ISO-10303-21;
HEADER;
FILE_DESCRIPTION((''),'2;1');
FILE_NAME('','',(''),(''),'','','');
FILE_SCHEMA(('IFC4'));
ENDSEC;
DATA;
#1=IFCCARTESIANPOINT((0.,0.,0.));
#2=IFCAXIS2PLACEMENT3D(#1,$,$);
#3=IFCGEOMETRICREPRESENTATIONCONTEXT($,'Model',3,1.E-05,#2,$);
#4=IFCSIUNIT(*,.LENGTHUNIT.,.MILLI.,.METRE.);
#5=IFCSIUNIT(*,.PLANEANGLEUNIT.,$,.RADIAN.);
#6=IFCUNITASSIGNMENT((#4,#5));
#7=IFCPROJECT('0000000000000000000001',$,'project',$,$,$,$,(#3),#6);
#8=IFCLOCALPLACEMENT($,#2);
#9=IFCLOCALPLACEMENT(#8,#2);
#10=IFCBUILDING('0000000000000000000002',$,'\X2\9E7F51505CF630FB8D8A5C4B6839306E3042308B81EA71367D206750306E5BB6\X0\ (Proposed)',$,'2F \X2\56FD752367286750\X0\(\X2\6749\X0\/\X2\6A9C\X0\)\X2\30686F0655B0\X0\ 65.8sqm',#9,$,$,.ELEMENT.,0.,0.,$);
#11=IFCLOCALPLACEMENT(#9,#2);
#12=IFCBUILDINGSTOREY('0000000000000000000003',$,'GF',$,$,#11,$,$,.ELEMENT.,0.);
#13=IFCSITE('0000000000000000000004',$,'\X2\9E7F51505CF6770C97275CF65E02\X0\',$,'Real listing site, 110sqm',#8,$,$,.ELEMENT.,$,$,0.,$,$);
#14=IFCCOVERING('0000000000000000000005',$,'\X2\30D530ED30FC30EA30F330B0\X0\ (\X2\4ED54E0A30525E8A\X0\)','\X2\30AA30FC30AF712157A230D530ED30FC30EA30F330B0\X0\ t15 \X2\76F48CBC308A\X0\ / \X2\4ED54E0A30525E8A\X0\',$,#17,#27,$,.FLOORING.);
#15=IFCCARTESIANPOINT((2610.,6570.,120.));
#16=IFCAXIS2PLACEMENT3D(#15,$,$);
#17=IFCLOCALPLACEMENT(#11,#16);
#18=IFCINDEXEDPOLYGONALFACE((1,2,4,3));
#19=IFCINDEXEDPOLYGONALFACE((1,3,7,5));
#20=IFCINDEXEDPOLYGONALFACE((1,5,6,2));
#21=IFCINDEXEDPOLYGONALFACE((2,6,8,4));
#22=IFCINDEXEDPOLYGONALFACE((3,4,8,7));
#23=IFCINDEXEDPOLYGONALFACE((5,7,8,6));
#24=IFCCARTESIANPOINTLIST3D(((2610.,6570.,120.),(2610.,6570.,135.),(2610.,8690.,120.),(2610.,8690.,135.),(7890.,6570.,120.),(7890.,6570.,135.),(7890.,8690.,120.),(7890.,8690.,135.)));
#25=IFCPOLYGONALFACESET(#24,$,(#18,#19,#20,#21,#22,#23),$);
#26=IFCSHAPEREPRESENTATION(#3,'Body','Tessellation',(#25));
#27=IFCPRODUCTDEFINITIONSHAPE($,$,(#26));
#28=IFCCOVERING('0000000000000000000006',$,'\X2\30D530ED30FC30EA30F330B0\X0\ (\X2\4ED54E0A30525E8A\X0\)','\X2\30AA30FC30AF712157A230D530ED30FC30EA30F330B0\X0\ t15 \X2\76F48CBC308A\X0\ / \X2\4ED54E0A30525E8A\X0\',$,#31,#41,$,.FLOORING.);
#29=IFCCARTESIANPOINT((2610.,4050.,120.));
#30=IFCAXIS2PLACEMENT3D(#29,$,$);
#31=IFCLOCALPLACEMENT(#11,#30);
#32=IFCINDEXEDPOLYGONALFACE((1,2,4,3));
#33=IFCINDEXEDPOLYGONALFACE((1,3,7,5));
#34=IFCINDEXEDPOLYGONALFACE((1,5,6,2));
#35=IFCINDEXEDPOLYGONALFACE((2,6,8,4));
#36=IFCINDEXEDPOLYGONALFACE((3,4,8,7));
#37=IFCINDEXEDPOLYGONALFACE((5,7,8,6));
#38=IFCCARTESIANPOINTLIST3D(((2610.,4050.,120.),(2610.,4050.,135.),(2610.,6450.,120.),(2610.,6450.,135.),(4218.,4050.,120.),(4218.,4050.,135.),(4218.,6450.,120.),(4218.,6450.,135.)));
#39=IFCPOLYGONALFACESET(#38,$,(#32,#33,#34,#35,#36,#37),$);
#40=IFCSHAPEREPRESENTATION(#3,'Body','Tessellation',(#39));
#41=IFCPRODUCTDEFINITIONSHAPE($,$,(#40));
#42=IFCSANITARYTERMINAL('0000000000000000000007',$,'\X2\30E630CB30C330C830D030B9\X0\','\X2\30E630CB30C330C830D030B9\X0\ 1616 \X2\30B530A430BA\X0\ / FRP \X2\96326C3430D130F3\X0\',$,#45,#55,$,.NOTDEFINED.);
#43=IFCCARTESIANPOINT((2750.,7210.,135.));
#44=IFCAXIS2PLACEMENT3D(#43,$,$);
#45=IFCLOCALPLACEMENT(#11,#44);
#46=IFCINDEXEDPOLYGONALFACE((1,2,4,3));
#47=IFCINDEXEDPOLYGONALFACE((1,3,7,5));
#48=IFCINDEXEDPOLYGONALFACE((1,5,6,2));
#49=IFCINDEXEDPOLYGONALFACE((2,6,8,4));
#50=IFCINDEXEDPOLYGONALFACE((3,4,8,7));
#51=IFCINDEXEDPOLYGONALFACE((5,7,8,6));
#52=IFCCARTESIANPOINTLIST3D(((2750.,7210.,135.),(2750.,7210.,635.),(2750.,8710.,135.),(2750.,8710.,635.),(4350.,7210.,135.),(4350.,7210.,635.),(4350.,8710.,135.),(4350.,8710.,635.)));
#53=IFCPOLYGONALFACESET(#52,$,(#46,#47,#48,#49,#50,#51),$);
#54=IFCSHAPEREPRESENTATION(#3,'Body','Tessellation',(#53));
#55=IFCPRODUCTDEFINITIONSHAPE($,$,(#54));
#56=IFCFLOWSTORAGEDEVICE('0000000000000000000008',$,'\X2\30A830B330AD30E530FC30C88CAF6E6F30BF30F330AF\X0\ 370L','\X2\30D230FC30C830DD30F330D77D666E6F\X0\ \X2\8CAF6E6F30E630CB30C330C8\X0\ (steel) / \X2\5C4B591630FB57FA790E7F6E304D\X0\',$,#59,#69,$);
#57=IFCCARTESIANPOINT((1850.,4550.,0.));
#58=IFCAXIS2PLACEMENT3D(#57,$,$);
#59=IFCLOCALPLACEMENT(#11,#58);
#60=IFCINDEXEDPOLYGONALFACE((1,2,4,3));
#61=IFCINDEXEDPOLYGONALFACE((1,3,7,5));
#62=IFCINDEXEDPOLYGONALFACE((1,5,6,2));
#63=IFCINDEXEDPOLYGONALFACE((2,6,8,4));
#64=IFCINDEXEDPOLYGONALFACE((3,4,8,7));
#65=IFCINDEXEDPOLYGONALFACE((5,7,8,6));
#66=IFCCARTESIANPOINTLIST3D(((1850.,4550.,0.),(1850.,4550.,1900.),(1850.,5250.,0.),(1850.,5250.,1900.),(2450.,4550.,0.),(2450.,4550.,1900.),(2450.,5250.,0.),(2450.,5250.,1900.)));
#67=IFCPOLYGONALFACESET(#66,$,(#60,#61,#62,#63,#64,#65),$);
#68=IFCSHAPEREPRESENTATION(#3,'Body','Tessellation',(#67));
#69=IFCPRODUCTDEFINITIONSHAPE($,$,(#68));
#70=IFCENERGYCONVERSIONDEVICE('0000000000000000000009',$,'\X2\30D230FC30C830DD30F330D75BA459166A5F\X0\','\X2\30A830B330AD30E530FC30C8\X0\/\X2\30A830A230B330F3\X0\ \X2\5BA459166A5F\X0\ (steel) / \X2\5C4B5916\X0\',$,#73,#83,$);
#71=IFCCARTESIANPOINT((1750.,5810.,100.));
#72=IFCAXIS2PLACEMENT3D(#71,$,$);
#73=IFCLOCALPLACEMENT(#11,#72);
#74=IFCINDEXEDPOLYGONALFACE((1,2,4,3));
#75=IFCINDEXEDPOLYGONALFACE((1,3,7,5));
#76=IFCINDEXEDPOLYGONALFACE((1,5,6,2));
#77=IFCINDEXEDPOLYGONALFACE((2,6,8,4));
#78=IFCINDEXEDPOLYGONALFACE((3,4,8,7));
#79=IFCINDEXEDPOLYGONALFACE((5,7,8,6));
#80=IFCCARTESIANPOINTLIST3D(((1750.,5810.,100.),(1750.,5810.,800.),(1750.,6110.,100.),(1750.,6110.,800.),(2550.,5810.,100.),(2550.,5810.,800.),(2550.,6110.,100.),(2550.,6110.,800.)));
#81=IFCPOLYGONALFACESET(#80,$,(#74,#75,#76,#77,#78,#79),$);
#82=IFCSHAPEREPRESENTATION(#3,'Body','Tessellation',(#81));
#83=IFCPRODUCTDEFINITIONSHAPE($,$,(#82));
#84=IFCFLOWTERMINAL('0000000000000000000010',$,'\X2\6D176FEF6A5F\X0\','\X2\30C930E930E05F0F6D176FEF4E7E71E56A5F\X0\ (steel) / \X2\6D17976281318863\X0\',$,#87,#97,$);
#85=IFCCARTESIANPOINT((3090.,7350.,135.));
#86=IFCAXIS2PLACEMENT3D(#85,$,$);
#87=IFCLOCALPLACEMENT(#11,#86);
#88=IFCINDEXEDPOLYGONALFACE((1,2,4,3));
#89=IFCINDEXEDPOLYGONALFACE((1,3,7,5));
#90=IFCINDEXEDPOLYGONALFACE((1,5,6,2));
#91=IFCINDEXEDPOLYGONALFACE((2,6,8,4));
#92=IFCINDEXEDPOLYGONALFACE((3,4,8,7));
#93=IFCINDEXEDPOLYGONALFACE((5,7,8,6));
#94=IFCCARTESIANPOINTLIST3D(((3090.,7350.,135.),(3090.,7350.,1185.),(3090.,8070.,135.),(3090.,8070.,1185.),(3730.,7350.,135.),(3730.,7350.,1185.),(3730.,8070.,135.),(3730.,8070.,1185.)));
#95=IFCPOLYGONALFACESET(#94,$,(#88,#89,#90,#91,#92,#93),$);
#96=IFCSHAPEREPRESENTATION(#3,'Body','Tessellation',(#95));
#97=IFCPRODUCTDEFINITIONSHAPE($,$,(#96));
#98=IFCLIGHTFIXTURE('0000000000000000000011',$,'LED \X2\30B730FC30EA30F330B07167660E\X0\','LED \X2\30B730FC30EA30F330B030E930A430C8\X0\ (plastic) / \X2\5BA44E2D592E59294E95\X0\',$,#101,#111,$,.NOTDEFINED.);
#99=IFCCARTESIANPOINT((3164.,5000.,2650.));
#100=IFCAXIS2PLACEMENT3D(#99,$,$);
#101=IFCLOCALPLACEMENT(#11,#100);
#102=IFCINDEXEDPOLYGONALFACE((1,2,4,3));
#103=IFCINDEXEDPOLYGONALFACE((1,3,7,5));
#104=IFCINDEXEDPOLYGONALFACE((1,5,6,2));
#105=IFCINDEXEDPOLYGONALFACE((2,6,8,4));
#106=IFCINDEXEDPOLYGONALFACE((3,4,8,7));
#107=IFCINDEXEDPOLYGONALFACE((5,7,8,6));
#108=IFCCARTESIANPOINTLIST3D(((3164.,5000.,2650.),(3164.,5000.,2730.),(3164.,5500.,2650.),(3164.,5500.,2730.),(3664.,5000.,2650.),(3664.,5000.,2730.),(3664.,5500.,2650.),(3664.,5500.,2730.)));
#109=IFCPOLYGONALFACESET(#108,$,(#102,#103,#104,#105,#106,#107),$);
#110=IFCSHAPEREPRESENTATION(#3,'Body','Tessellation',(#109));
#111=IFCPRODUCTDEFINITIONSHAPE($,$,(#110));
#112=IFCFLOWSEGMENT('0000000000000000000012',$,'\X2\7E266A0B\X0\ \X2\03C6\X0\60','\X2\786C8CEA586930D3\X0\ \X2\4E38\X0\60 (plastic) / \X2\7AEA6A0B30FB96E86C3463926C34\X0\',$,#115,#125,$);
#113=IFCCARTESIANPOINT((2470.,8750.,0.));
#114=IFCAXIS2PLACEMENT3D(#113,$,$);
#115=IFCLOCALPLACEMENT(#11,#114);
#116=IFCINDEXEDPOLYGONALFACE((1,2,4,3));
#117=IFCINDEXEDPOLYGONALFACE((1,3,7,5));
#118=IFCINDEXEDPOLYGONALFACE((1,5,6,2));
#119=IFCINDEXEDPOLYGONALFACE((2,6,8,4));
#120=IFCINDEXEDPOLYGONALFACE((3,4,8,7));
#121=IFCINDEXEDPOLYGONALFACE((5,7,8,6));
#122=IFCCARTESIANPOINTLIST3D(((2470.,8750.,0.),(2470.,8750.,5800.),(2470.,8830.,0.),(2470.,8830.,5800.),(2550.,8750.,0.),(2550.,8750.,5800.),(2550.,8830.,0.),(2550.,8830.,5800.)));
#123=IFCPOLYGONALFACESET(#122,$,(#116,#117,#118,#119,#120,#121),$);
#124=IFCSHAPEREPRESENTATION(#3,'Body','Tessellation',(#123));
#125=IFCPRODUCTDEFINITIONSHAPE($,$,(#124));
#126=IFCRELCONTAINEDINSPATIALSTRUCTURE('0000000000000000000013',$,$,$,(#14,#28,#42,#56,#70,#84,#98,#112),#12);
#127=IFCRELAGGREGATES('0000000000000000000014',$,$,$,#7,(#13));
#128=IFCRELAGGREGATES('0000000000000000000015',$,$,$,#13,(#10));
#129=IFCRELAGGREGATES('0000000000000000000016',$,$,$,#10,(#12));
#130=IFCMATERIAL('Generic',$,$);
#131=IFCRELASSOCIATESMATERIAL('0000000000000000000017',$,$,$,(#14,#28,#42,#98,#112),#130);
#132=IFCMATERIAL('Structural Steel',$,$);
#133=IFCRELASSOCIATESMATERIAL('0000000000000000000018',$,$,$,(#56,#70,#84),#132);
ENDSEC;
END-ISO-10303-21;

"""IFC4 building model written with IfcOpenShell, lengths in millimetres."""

from ifc_helpers import new_model, si_unit, frame, frame_2d, origin, place, context, project, spatial, rectangle, extrude, material, element, save


model = new_model("IFC4")

# Units and contexts
model_context = context("Model", 3, precision=1e-05, world=origin())
ifc_project = project(units=[si_unit("LENGTHUNIT", "METRE", prefix="MILLI"), si_unit("PLANEANGLEUNIT", "RADIAN")], contexts=[model_context])

# Site, building, storey
site_placement = place(None, origin())
site = spatial("IfcSite", under=ifc_project, at=site_placement, Name="鹿児島県霧島市", ObjectType="Real listing site, 110sqm", CompositionType="ELEMENT", RefElevation=0.0)
building_placement = place(site_placement, origin())
building = spatial("IfcBuilding", under=site, at=building_placement, Name="鹿児島・越屋根のある自然素材の家 (Proposed)", ObjectType="2F 国産木材(杉/檜)と漆喰 65.8sqm", CompositionType="ELEMENT", ElevationOfRefHeight=0.0, ElevationOfTerrain=0.0)
storey_placement = place(building_placement, origin())
storey = spatial("IfcBuildingStorey", under=building, at=storey_placement, Name="GF", CompositionType="ELEMENT", Elevation=0.0)

# Coverings
ifc_material_1 = material(Name="Generic")
covering_1_placement = place(storey_placement, frame((2610.0, 6570.0, 120.0)))
element("IfcCovering", 1, at=covering_1_placement, inside=storey, material=ifc_material_1, Name="フローリング (仕上げ床)", Description="オーク無垢フローリング t15 直貼り / 仕上げ床", PredefinedType="FLOORING", context=model_context, shape_type="SweptSolid", body=[
    extrude(rectangle(XDim=5280.0, YDim=2120.0, at=frame_2d((2640.0, 1060.0))), frame((2610.0, 6570.0, 120.0)), (0.0, 0.0, 1.0), 15.0),
])
covering_2_placement = place(storey_placement, frame((2610.0, 4050.0, 120.0)))
element("IfcCovering", 2, at=covering_2_placement, inside=storey, material=ifc_material_1, Name="フローリング (仕上げ床)", Description="オーク無垢フローリング t15 直貼り / 仕上げ床", PredefinedType="FLOORING", context=model_context, shape_type="SweptSolid", body=[
    extrude(rectangle(XDim=1608.0, YDim=2400.0, at=frame_2d((804.0, 1200.0))), frame((2610.0, 4050.0, 120.0)), (0.0, 0.0, 1.0), 15.0),
])

# Sanitary terminal
sanitary_terminal_placement = place(storey_placement, frame((2750.0, 7210.0, 135.0)))
element("IfcSanitaryTerminal", 3, at=sanitary_terminal_placement, inside=storey, material=ifc_material_1, Name="ユニットバス", Description="ユニットバス 1616 サイズ / FRP 防水パン", PredefinedType="NOTDEFINED", context=model_context, shape_type="SweptSolid", body=[
    extrude(rectangle(XDim=1600.0, YDim=1500.0, at=frame_2d((800.0, 750.0))), frame((2750.0, 7210.0, 135.0)), (0.0, 0.0, 1.0), 500.0),
])

# Flow storage device
ifc_material_2 = material(Name="Structural Steel")
flow_storage_device_placement = place(storey_placement, frame((1850.0, 4550.0, 0.0)))
element("IfcFlowStorageDevice", 4, at=flow_storage_device_placement, inside=storey, material=ifc_material_2, Name="エコキュート貯湯タンク 370L", Description="ヒートポンプ給湯 貯湯ユニット (steel) / 屋外・基礎置き", context=model_context, shape_type="SweptSolid", body=[
    extrude(rectangle(XDim=600.0, YDim=700.0, at=frame_2d((300.0, 350.0))), frame((1850.0, 4550.0, 0.0)), (0.0, 0.0, 1.0), 1900.0),
])

# Energy conversion device
energy_conversion_device_placement = place(storey_placement, frame((1750.0, 5810.0, 100.0)))
element("IfcEnergyConversionDevice", 5, at=energy_conversion_device_placement, inside=storey, material=ifc_material_2, Name="ヒートポンプ室外機", Description="エコキュート/エアコン 室外機 (steel) / 屋外", context=model_context, shape_type="SweptSolid", body=[
    extrude(rectangle(XDim=800.0, YDim=300.0, at=frame_2d((400.0, 150.0))), frame((1750.0, 5810.0, 100.0)), (0.0, 0.0, 1.0), 700.0),
])

# Flow terminal
flow_terminal_placement = place(storey_placement, frame((3090.0, 7350.0, 135.0)))
element("IfcFlowTerminal", 6, at=flow_terminal_placement, inside=storey, material=ifc_material_2, Name="洗濯機", Description="ドラム式洗濯乾燥機 (steel) / 洗面脱衣", context=model_context, shape_type="SweptSolid", body=[
    extrude(rectangle(XDim=640.0, YDim=720.0, at=frame_2d((320.0, 360.0))), frame((3090.0, 7350.0, 135.0)), (0.0, 0.0, 1.0), 1050.0),
])

# Light fixture
light_fixture_placement = place(storey_placement, frame((3164.0, 5000.0, 2650.0)))
element("IfcLightFixture", 7, at=light_fixture_placement, inside=storey, material=ifc_material_1, Name="LED シーリング照明", Description="LED シーリングライト (plastic) / 室中央天井", PredefinedType="NOTDEFINED", context=model_context, shape_type="SweptSolid", body=[
    extrude(rectangle(XDim=500.0, YDim=500.0, at=frame_2d((250.0, 250.0))), frame((3164.0, 5000.0, 2650.0)), (0.0, 0.0, 1.0), 80.0),
])

# Flow segment
flow_segment_placement = place(storey_placement, frame((2470.0, 8750.0, 0.0)))
element("IfcFlowSegment", 8, at=flow_segment_placement, inside=storey, material=ifc_material_1, Name="縦樋 φ60", Description="硬質塩ビ 丸60 (plastic) / 竪樋・雨水排水", context=model_context, shape_type="SweptSolid", body=[
    extrude(rectangle(XDim=80.0, YDim=80.0, at=frame_2d((40.0, 40.0))), frame((2470.0, 8750.0, 0.0)), (0.0, 0.0, 1.0), 5800.0),
])

save(model, "model.ifc")
